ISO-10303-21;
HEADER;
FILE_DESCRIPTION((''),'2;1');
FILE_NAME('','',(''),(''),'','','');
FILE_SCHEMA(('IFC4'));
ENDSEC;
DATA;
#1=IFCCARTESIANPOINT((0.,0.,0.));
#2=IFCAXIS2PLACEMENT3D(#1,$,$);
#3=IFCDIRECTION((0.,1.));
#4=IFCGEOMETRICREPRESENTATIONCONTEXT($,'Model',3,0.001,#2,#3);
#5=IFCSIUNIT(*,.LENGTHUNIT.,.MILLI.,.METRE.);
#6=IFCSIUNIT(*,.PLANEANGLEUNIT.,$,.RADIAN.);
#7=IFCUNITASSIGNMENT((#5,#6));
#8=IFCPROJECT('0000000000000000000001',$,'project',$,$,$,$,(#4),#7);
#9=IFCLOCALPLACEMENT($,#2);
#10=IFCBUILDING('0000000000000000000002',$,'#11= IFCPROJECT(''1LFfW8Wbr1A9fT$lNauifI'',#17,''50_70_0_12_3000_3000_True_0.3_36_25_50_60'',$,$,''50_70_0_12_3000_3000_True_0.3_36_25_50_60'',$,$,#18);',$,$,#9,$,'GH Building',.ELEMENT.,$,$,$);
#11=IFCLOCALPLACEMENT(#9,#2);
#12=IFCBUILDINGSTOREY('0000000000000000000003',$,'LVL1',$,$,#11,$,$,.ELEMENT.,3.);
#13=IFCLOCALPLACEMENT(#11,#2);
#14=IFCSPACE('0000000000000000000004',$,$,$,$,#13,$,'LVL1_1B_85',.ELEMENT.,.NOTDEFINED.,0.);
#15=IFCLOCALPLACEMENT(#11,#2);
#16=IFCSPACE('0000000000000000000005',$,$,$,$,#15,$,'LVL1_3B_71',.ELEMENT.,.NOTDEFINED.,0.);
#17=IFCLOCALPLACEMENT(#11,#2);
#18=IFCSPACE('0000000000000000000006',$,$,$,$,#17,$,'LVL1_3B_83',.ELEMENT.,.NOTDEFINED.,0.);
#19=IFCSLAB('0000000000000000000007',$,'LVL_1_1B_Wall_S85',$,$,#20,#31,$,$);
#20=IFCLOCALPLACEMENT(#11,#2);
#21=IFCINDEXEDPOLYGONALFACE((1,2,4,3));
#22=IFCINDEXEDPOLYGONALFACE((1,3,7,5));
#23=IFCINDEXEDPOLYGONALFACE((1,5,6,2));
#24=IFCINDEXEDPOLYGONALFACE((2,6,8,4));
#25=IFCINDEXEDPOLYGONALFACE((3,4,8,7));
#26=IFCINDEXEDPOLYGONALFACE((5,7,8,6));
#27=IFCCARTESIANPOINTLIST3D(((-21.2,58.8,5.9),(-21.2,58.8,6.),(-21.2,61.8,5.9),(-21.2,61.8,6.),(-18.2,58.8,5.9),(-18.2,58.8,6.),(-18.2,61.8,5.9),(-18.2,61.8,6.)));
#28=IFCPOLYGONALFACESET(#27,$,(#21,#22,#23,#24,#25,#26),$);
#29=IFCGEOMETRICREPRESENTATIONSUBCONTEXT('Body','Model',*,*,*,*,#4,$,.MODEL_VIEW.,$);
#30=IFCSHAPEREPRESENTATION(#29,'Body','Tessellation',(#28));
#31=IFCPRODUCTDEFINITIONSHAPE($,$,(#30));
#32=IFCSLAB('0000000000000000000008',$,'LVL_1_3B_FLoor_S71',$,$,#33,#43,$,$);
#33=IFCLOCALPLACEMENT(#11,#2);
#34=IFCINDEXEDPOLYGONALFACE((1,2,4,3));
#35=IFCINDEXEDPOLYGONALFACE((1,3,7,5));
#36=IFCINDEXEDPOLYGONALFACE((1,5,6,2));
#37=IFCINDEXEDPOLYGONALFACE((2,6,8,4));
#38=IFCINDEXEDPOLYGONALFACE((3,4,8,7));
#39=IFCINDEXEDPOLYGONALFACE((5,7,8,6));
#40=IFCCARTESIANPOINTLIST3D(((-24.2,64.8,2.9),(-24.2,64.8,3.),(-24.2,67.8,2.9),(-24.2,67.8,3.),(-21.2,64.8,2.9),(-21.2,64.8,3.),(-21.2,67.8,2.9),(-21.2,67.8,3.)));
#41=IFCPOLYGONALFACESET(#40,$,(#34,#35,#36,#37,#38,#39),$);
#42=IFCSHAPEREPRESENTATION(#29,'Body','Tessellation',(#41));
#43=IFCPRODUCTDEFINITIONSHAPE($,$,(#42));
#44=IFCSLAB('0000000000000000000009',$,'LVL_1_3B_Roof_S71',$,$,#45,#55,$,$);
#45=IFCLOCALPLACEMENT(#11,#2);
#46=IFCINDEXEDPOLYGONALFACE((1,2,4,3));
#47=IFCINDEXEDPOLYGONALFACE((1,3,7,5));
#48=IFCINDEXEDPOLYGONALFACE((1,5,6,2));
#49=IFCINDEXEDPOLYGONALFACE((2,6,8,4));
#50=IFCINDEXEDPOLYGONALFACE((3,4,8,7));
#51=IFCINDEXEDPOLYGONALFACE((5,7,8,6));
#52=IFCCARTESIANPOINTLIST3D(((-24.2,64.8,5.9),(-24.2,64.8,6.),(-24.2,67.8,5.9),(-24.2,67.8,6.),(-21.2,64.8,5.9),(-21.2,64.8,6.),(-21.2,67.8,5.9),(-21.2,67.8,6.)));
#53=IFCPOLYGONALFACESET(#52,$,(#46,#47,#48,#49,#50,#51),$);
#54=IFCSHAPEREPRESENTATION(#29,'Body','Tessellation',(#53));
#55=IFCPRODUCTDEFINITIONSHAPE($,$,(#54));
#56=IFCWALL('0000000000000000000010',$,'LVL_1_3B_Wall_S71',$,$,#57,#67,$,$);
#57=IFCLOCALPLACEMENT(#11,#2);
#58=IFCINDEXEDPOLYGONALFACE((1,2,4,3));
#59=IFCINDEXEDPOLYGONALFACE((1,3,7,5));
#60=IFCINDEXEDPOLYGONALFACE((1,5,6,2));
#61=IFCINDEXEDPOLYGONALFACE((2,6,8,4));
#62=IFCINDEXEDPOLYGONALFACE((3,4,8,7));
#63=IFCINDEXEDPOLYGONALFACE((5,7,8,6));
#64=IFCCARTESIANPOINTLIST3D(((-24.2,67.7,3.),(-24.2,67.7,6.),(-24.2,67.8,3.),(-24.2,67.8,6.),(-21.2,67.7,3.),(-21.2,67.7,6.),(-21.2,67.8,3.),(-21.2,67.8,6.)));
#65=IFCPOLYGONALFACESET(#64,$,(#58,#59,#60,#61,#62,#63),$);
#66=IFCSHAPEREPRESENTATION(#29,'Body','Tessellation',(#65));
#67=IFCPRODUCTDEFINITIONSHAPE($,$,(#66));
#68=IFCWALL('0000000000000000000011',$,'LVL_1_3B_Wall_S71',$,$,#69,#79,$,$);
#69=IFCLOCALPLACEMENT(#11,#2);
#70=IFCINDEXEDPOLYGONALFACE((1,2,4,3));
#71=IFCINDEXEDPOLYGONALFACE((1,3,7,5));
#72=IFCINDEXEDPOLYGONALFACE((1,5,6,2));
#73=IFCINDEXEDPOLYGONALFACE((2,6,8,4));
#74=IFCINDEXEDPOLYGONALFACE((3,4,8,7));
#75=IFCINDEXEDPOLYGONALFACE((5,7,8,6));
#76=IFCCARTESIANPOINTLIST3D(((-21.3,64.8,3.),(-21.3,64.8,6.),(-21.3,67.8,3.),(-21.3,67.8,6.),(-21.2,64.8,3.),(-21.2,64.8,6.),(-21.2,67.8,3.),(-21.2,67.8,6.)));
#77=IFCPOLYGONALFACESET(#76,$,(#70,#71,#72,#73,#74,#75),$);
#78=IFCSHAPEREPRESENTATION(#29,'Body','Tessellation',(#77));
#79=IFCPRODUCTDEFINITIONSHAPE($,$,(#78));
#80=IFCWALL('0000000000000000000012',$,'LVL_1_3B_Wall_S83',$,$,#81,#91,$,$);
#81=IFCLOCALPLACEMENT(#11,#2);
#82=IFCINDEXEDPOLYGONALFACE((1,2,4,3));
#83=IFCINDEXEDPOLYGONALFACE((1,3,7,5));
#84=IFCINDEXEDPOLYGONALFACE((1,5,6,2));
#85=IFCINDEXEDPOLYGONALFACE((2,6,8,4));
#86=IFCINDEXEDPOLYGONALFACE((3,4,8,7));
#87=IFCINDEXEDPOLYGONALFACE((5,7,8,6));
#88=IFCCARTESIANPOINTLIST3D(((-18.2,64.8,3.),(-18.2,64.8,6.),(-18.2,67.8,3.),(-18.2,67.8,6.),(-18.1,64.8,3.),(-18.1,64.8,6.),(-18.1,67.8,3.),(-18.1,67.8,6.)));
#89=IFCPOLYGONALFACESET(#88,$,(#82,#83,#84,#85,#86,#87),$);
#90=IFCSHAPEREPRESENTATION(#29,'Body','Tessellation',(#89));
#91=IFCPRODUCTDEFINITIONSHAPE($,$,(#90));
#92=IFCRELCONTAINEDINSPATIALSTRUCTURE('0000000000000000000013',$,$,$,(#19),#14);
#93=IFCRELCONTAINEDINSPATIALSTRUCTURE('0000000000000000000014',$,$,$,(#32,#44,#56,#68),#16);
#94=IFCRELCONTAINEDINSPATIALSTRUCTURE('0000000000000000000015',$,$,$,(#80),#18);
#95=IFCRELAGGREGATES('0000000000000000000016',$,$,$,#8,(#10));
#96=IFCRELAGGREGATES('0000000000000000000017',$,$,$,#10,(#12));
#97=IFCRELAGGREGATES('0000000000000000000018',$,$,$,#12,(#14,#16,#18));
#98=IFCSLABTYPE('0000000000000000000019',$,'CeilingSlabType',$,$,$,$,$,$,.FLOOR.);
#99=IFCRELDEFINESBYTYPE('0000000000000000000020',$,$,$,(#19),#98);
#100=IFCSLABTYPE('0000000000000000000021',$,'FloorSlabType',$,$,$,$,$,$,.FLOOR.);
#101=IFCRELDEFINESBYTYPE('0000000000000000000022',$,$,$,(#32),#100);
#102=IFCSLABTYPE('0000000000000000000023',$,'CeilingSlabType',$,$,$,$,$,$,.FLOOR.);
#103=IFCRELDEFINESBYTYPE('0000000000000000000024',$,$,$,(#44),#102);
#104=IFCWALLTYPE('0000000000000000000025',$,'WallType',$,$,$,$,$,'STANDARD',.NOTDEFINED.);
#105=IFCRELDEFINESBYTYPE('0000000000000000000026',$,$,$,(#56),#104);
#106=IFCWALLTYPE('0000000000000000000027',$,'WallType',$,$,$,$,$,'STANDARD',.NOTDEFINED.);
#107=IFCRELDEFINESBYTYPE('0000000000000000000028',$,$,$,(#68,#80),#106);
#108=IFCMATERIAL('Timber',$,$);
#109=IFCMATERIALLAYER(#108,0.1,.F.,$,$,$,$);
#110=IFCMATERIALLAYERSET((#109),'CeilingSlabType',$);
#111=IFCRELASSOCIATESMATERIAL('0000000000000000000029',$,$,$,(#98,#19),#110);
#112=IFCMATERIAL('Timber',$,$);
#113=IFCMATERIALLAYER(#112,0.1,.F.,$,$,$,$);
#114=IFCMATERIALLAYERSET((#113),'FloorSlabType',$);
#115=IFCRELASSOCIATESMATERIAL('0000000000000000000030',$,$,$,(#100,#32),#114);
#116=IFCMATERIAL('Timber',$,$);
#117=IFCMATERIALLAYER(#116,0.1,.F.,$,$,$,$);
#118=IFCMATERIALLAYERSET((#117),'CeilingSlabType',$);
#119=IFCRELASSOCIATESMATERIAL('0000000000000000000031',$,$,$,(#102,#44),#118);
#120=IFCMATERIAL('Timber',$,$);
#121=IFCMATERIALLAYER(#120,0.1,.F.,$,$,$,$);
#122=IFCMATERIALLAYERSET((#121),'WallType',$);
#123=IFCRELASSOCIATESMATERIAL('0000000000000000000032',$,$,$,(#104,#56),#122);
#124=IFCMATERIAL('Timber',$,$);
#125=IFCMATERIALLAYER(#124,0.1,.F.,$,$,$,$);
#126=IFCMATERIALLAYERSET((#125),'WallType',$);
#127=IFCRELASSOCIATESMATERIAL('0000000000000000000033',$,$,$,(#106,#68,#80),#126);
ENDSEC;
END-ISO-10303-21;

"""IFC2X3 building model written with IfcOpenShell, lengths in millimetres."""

from ifc_helpers import new_model, si_unit, direction, frame, frame_2d, origin, place, context, subcontext, project, spatial, rectangle, extrude, material, layer, layer_set, layer_usage, type_object, element, save


model = new_model("IFC2X3")

# Units and contexts
model_context = context("Model", 3, precision=0.001, world=origin(), true_north=direction((0.0, 1.0)))
body_context = subcontext(model_context, "Body", "Model", "MODEL_VIEW")
ifc_project = project(units=[si_unit("LENGTHUNIT", "METRE", prefix="MILLI"), si_unit("PLANEANGLEUNIT", "RADIAN")], contexts=[model_context])

# Building, storey
building_placement = place(None, origin())
building = spatial("IfcBuilding", under=ifc_project, at=building_placement, Name="#11= IFCPROJECT('1LFfW8Wbr1A9fT$lNauifI',#17,'50_70_0_12_3000_3000_True_0.3_36_25_50_60',$,$,'50_70_0_12_3000_3000_True_0.3_36_25_50_60',$,$,#18);", LongName="GH Building", CompositionType="ELEMENT")
storey_placement = place(building_placement, origin())
storey = spatial("IfcBuildingStorey", under=building, at=storey_placement, Name="LVL1", CompositionType="ELEMENT", Elevation=3.0)

# Shared definitions
space_1_placement = place(storey_placement, origin())
space_1 = spatial("IfcSpace", under=storey, at=space_1_placement, LongName="LVL1_1B_85", CompositionType="ELEMENT", InteriorOrExteriorSpace="NOTDEFINED", ElevationWithFlooring=0.0)

# Slab
ifc_material_1 = material(Name="Timber")
ifc_layer_1 = layer(ifc_material_1, 0.1, ventilated=False)
ifc_layer_set_1 = layer_set([ifc_layer_1], Name="CeilingSlabType")
ifc_layer_usage_1 = layer_usage(ifc_layer_set_1, "AXIS3", "NEGATIVE", -0.1)
slab_type_1 = type_object("IfcSlabType", Name="CeilingSlabType", PredefinedType="FLOOR", material=ifc_layer_set_1)
slab_1_placement = place(space_1_placement, frame((-21.2, 61.8, 5.9), z_axis=(0.0, 0.0, 1.0), x_axis=(0.0, -1.0, 0.0)))
element("IfcSlab", 1, at=slab_1_placement, inside=space_1, type_object=slab_type_1, material=ifc_layer_usage_1, Name="LVL_1_1B_Wall_S85", context=body_context, shape_type="SweptSolid", body=[
    extrude(rectangle(XDim=3.0, YDim=3.0, at=frame_2d((1.5, 1.5))), origin(), (0.0, 0.0, 1.0), 0.1),
])

# Shared definitions
space_2_placement = place(storey_placement, origin())
space_2 = spatial("IfcSpace", under=storey, at=space_2_placement, LongName="LVL1_3B_71", CompositionType="ELEMENT", InteriorOrExteriorSpace="NOTDEFINED", ElevationWithFlooring=0.0)

# Slabs
ifc_material_2 = material(Name="Timber")
ifc_layer_2 = layer(ifc_material_2, 0.1, ventilated=False)
ifc_layer_set_2 = layer_set([ifc_layer_2], Name="FloorSlabType")
ifc_layer_usage_2 = layer_usage(ifc_layer_set_2, "AXIS3", "NEGATIVE", -0.1)
slab_type_2 = type_object("IfcSlabType", Name="FloorSlabType", PredefinedType="FLOOR", material=ifc_layer_set_2)
slab_2_placement = place(space_2_placement, frame((-24.2, 64.8, 2.9)))
element("IfcSlab", 2, at=slab_2_placement, inside=space_2, type_object=slab_type_2, material=ifc_layer_usage_2, Name="LVL_1_3B_FLoor_S71", context=body_context, shape_type="SweptSolid", body=[
    extrude(rectangle(XDim=3.0, YDim=3.0, at=frame_2d((1.5, 1.5))), origin(), (0.0, 0.0, 1.0), 0.1),
])
ifc_material_3 = material(Name="Timber")
ifc_layer_3 = layer(ifc_material_3, 0.1, ventilated=False)
ifc_layer_set_3 = layer_set([ifc_layer_3], Name="CeilingSlabType")
ifc_layer_usage_3 = layer_usage(ifc_layer_set_3, "AXIS3", "NEGATIVE", -0.1)
slab_type_3 = type_object("IfcSlabType", Name="CeilingSlabType", PredefinedType="FLOOR", material=ifc_layer_set_3)
slab_3_placement = place(space_2_placement, frame((-24.2, 64.8, 5.9)))
element("IfcSlab", 3, at=slab_3_placement, inside=space_2, type_object=slab_type_3, material=ifc_layer_usage_3, Name="LVL_1_3B_Roof_S71", context=body_context, shape_type="SweptSolid", body=[
    extrude(rectangle(XDim=3.0, YDim=3.0, at=frame_2d((1.5, 1.5))), origin(), (0.0, 0.0, 1.0), 0.1),
])

# Walls
ifc_material_4 = material(Name="Timber")
ifc_layer_4 = layer(ifc_material_4, 0.1, ventilated=False)
ifc_layer_set_4 = layer_set([ifc_layer_4], Name="WallType")
ifc_layer_usage_4 = layer_usage(ifc_layer_set_4, "AXIS2", "NEGATIVE", 0.0)
wall_type_1 = type_object("IfcWallType", Name="WallType", ElementType="STANDARD", PredefinedType="NOTDEFINED", material=ifc_layer_set_4)
wall_1_placement = place(space_2_placement, frame((-24.2, 67.8, 3.0)))
element("IfcWall", 4, at=wall_1_placement, inside=space_2, type_object=wall_type_1, material=ifc_layer_usage_4, Name="LVL_1_3B_Wall_S71", context=body_context, shape_type="SweptSolid", body=[
    extrude(rectangle(XDim=3.0, YDim=0.1, at=frame_2d((1.5, -0.1))), origin(), (0.0, 0.0, 1.0), 3.0),
])
ifc_material_5 = material(Name="Timber")
ifc_layer_5 = layer(ifc_material_5, 0.1, ventilated=False)
ifc_layer_set_5 = layer_set([ifc_layer_5], Name="WallType")
ifc_layer_usage_5 = layer_usage(ifc_layer_set_5, "AXIS2", "NEGATIVE", 0.0)
wall_type_2 = type_object("IfcWallType", Name="WallType", ElementType="STANDARD", PredefinedType="NOTDEFINED", material=ifc_layer_set_5)
wall_2_placement = place(space_2_placement, frame((-21.2, 67.8, 3.0), z_axis=(0.0, 0.0, 1.0), x_axis=(0.0, -1.0, 0.0)))
element("IfcWall", 5, at=wall_2_placement, inside=space_2, type_object=wall_type_2, material=ifc_layer_usage_5, Name="LVL_1_3B_Wall_S71", context=body_context, shape_type="SweptSolid", body=[
    extrude(rectangle(XDim=3.0, YDim=0.1, at=frame_2d((1.5, -0.1))), origin(), (0.0, 0.0, 1.0), 3.0),
])

# Shared definitions
space_3_placement = place(storey_placement, origin())
space_3 = spatial("IfcSpace", under=storey, at=space_3_placement, LongName="LVL1_3B_83", CompositionType="ELEMENT", InteriorOrExteriorSpace="NOTDEFINED", ElevationWithFlooring=0.0)

# Wall
ifc_layer_usage_6 = layer_usage(ifc_layer_set_5, "AXIS2", "NEGATIVE", 0.0)
wall_3_placement = place(space_3_placement, frame((-18.2, 64.8, 3.0), z_axis=(0.0, 0.0, 1.0), x_axis=(0.0, 1.0, 0.0)))
element("IfcWall", 6, at=wall_3_placement, inside=space_3, type_object=wall_type_2, material=ifc_layer_usage_6, Name="LVL_1_3B_Wall_S83", context=body_context, shape_type="SweptSolid", body=[
    extrude(rectangle(XDim=3.0, YDim=0.1, at=frame_2d((1.5, -0.1))), origin(), (0.0, 0.0, 1.0), 3.0),
])

save(model, "model.ifc")
